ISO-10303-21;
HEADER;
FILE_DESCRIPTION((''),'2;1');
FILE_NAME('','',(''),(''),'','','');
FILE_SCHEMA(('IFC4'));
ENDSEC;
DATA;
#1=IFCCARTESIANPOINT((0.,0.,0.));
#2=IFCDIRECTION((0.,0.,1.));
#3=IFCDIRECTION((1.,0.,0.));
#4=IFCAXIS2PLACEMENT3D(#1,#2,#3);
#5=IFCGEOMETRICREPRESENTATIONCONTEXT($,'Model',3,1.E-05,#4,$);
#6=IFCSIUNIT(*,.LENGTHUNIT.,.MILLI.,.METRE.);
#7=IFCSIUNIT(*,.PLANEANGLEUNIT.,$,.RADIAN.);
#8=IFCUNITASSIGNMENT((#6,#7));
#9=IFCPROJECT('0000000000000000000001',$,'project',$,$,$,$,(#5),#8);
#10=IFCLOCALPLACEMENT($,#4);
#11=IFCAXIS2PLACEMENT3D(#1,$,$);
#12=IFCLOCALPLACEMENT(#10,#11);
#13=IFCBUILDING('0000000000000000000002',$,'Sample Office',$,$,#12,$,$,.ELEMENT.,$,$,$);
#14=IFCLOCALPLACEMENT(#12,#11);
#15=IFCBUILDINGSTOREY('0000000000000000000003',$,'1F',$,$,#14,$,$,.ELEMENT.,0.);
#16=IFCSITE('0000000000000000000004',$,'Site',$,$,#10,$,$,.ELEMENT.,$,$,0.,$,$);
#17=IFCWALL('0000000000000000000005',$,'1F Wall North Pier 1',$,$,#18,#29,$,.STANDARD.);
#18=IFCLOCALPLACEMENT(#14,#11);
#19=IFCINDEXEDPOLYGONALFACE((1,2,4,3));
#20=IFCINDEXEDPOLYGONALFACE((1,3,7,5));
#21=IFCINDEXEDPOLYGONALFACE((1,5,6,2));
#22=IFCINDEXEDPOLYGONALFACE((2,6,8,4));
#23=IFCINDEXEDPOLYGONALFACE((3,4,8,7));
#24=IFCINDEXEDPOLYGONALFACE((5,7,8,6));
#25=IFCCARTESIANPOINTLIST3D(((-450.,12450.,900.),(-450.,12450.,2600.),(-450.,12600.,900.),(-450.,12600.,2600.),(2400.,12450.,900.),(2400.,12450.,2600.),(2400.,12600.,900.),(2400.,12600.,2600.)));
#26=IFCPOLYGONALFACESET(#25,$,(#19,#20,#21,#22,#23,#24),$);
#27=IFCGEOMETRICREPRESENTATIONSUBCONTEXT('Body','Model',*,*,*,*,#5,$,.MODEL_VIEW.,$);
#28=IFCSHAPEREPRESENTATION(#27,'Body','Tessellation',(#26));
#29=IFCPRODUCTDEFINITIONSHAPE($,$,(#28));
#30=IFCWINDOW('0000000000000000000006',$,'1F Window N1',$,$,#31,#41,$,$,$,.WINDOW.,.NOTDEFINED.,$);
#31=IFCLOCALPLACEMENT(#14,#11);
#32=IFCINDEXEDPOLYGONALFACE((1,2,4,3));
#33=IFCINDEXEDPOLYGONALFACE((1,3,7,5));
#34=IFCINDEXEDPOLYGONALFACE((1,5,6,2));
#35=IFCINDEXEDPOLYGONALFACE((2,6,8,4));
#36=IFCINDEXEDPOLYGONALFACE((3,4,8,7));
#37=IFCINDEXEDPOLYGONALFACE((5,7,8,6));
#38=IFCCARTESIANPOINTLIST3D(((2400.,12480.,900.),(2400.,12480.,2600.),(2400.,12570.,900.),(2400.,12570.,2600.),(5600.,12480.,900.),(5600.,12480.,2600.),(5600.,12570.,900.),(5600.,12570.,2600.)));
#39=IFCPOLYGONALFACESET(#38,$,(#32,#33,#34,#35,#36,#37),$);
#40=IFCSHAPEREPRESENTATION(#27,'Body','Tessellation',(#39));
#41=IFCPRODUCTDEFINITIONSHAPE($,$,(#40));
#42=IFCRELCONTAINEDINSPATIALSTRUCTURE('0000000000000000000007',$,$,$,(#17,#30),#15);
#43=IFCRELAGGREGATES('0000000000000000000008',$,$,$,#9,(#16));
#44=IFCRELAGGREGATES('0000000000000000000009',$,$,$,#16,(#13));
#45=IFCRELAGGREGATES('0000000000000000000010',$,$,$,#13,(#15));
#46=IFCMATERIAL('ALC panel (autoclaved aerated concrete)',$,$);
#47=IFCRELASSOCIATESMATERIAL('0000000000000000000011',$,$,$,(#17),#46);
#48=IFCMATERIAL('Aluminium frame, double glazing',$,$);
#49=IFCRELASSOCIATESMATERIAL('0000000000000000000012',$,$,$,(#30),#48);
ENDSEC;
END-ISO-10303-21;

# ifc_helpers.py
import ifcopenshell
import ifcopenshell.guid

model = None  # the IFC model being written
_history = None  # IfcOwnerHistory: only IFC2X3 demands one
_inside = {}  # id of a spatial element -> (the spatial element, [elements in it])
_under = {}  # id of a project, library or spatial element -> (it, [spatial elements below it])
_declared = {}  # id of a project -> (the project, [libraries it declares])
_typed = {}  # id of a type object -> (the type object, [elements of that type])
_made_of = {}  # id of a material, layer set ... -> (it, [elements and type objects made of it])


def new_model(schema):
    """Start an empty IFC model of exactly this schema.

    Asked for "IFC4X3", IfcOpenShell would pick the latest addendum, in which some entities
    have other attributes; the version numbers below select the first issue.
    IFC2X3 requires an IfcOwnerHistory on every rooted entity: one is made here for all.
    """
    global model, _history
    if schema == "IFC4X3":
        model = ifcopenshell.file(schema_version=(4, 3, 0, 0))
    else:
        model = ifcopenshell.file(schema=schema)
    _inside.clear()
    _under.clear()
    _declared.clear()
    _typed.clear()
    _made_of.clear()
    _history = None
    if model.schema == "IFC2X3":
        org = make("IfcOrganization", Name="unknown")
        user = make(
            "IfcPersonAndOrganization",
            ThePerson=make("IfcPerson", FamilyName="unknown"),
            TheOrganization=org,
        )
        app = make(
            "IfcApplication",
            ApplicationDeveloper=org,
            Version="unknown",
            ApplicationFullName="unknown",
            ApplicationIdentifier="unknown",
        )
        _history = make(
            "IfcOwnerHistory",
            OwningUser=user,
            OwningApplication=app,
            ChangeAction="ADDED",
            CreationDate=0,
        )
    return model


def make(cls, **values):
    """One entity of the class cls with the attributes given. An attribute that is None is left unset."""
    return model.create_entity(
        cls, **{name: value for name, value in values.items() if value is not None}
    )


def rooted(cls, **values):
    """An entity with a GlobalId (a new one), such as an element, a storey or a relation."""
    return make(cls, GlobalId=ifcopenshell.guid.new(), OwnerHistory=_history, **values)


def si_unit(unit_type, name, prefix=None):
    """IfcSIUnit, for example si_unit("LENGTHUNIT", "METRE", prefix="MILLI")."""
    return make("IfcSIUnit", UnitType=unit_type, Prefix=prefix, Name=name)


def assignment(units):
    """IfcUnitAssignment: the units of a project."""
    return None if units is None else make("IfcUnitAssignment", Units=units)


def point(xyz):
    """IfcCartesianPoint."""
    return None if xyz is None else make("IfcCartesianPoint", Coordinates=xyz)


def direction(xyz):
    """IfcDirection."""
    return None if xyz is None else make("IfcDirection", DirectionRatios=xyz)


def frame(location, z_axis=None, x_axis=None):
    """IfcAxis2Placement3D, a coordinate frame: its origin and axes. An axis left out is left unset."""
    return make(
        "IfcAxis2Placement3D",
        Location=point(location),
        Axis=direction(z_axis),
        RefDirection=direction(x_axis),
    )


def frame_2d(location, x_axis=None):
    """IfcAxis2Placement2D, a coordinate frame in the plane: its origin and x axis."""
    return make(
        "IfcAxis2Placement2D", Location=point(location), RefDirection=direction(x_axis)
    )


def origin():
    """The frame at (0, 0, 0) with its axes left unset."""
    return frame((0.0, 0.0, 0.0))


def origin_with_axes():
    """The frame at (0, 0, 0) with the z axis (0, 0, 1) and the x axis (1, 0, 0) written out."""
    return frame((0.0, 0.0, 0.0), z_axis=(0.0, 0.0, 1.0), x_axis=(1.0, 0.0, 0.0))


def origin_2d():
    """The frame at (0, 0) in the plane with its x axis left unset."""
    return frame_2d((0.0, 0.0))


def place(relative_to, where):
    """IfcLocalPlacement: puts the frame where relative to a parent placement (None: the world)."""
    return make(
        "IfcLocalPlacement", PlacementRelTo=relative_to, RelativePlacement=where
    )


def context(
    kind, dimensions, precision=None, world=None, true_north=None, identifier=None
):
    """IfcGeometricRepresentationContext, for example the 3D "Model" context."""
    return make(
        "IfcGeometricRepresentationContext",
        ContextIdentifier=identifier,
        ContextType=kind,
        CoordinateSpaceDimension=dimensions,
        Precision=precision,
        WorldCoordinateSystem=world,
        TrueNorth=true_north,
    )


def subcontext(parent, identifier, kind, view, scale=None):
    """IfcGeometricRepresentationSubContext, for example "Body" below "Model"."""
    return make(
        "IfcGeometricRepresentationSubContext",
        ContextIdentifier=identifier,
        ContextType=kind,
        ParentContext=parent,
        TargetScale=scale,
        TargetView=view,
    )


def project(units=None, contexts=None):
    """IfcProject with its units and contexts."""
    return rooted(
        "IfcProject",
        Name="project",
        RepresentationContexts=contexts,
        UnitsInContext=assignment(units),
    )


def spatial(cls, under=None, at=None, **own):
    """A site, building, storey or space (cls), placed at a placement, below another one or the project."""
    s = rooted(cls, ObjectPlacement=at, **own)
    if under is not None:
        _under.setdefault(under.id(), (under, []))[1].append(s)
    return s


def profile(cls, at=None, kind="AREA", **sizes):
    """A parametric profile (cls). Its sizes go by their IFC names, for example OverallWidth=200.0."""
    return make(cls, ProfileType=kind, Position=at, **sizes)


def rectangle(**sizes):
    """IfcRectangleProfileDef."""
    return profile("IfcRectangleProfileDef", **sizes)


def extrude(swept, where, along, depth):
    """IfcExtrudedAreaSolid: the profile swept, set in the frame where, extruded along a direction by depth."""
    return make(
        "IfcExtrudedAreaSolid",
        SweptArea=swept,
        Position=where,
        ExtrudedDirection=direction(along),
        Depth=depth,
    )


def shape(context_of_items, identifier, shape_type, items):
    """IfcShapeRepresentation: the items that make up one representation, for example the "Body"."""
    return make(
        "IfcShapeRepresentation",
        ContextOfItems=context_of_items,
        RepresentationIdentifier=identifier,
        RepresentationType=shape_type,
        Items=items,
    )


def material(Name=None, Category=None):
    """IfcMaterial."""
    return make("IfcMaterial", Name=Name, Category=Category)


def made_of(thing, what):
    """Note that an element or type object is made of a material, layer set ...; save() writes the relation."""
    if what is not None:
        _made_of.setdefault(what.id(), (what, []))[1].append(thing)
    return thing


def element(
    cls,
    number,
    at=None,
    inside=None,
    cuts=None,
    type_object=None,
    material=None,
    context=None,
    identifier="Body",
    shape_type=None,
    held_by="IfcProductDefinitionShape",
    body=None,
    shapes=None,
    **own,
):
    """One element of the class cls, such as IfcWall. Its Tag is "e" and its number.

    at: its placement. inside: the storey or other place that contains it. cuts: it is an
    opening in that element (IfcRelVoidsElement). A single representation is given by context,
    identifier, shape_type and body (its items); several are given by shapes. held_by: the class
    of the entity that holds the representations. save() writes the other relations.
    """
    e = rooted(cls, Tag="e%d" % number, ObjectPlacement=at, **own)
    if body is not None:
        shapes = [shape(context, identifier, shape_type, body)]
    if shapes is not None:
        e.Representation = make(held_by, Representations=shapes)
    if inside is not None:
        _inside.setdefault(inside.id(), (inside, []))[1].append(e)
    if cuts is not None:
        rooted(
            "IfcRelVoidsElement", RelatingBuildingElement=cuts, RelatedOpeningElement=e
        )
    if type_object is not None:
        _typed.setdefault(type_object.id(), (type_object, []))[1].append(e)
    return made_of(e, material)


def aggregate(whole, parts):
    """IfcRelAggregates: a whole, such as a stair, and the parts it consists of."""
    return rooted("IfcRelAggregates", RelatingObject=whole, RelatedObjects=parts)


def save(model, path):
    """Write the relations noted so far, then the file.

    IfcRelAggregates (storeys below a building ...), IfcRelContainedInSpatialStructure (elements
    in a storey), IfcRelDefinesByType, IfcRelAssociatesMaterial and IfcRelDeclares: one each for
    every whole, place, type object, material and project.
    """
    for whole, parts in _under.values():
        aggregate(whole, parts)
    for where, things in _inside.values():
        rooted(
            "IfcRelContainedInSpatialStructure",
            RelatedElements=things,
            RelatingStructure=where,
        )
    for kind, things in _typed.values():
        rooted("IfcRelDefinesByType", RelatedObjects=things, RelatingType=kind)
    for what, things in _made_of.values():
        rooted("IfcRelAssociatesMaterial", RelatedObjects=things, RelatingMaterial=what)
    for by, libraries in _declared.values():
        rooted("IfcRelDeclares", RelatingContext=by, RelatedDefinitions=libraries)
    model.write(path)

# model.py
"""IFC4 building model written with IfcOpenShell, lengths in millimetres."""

from ifc_helpers import new_model, si_unit, frame, origin, origin_with_axes, origin_2d, place, context, subcontext, project, spatial, rectangle, extrude, material, element, save


model = new_model("IFC4")

# Units and contexts
model_context = context("Model", 3, precision=1e-05, world=origin_with_axes())
body_context = subcontext(model_context, "Body", "Model", "MODEL_VIEW")
ifc_project = project(units=[si_unit("LENGTHUNIT", "METRE", prefix="MILLI"), si_unit("PLANEANGLEUNIT", "RADIAN")], contexts=[model_context])

# Site, building, storey
site_placement = place(None, origin_with_axes())
site = spatial("IfcSite", under=ifc_project, at=site_placement, Name="Site", CompositionType="ELEMENT", RefElevation=0.0)
building_placement = place(site_placement, origin())
building = spatial("IfcBuilding", under=site, at=building_placement, Name="Sample Office", CompositionType="ELEMENT")
storey_placement = place(building_placement, origin())
storey = spatial("IfcBuildingStorey", under=building, at=storey_placement, Name="1F", CompositionType="ELEMENT", Elevation=0.0)

# Wall
ifc_material_1 = material(Name="ALC panel (autoclaved aerated concrete)")
wall_1_placement = place(storey_placement, frame((975.0, 12525.0, 900.0)))
element("IfcWall", 1, at=wall_1_placement, inside=storey, material=ifc_material_1, Name="1F Wall North Pier 1", PredefinedType="STANDARD", context=body_context, shape_type="SweptSolid", body=[
    extrude(rectangle(XDim=2850.0, YDim=150.0, at=origin_2d()), origin(), (0.0, 0.0, 1.0), 1700.0),
])

# Window
ifc_material_2 = material(Name="Aluminium frame, double glazing")
window_placement = place(storey_placement, frame((4000.0, 12525.0, 900.0)))
element("IfcWindow", 2, at=window_placement, inside=storey, material=ifc_material_2, Name="1F Window N1", PartitioningType="NOTDEFINED", PredefinedType="WINDOW", context=body_context, shape_type="SweptSolid", body=[
    extrude(rectangle(XDim=3200.0, YDim=90.0, at=origin_2d()), origin(), (0.0, 0.0, 1.0), 1700.0),
])

save(model, "model.ifc")
